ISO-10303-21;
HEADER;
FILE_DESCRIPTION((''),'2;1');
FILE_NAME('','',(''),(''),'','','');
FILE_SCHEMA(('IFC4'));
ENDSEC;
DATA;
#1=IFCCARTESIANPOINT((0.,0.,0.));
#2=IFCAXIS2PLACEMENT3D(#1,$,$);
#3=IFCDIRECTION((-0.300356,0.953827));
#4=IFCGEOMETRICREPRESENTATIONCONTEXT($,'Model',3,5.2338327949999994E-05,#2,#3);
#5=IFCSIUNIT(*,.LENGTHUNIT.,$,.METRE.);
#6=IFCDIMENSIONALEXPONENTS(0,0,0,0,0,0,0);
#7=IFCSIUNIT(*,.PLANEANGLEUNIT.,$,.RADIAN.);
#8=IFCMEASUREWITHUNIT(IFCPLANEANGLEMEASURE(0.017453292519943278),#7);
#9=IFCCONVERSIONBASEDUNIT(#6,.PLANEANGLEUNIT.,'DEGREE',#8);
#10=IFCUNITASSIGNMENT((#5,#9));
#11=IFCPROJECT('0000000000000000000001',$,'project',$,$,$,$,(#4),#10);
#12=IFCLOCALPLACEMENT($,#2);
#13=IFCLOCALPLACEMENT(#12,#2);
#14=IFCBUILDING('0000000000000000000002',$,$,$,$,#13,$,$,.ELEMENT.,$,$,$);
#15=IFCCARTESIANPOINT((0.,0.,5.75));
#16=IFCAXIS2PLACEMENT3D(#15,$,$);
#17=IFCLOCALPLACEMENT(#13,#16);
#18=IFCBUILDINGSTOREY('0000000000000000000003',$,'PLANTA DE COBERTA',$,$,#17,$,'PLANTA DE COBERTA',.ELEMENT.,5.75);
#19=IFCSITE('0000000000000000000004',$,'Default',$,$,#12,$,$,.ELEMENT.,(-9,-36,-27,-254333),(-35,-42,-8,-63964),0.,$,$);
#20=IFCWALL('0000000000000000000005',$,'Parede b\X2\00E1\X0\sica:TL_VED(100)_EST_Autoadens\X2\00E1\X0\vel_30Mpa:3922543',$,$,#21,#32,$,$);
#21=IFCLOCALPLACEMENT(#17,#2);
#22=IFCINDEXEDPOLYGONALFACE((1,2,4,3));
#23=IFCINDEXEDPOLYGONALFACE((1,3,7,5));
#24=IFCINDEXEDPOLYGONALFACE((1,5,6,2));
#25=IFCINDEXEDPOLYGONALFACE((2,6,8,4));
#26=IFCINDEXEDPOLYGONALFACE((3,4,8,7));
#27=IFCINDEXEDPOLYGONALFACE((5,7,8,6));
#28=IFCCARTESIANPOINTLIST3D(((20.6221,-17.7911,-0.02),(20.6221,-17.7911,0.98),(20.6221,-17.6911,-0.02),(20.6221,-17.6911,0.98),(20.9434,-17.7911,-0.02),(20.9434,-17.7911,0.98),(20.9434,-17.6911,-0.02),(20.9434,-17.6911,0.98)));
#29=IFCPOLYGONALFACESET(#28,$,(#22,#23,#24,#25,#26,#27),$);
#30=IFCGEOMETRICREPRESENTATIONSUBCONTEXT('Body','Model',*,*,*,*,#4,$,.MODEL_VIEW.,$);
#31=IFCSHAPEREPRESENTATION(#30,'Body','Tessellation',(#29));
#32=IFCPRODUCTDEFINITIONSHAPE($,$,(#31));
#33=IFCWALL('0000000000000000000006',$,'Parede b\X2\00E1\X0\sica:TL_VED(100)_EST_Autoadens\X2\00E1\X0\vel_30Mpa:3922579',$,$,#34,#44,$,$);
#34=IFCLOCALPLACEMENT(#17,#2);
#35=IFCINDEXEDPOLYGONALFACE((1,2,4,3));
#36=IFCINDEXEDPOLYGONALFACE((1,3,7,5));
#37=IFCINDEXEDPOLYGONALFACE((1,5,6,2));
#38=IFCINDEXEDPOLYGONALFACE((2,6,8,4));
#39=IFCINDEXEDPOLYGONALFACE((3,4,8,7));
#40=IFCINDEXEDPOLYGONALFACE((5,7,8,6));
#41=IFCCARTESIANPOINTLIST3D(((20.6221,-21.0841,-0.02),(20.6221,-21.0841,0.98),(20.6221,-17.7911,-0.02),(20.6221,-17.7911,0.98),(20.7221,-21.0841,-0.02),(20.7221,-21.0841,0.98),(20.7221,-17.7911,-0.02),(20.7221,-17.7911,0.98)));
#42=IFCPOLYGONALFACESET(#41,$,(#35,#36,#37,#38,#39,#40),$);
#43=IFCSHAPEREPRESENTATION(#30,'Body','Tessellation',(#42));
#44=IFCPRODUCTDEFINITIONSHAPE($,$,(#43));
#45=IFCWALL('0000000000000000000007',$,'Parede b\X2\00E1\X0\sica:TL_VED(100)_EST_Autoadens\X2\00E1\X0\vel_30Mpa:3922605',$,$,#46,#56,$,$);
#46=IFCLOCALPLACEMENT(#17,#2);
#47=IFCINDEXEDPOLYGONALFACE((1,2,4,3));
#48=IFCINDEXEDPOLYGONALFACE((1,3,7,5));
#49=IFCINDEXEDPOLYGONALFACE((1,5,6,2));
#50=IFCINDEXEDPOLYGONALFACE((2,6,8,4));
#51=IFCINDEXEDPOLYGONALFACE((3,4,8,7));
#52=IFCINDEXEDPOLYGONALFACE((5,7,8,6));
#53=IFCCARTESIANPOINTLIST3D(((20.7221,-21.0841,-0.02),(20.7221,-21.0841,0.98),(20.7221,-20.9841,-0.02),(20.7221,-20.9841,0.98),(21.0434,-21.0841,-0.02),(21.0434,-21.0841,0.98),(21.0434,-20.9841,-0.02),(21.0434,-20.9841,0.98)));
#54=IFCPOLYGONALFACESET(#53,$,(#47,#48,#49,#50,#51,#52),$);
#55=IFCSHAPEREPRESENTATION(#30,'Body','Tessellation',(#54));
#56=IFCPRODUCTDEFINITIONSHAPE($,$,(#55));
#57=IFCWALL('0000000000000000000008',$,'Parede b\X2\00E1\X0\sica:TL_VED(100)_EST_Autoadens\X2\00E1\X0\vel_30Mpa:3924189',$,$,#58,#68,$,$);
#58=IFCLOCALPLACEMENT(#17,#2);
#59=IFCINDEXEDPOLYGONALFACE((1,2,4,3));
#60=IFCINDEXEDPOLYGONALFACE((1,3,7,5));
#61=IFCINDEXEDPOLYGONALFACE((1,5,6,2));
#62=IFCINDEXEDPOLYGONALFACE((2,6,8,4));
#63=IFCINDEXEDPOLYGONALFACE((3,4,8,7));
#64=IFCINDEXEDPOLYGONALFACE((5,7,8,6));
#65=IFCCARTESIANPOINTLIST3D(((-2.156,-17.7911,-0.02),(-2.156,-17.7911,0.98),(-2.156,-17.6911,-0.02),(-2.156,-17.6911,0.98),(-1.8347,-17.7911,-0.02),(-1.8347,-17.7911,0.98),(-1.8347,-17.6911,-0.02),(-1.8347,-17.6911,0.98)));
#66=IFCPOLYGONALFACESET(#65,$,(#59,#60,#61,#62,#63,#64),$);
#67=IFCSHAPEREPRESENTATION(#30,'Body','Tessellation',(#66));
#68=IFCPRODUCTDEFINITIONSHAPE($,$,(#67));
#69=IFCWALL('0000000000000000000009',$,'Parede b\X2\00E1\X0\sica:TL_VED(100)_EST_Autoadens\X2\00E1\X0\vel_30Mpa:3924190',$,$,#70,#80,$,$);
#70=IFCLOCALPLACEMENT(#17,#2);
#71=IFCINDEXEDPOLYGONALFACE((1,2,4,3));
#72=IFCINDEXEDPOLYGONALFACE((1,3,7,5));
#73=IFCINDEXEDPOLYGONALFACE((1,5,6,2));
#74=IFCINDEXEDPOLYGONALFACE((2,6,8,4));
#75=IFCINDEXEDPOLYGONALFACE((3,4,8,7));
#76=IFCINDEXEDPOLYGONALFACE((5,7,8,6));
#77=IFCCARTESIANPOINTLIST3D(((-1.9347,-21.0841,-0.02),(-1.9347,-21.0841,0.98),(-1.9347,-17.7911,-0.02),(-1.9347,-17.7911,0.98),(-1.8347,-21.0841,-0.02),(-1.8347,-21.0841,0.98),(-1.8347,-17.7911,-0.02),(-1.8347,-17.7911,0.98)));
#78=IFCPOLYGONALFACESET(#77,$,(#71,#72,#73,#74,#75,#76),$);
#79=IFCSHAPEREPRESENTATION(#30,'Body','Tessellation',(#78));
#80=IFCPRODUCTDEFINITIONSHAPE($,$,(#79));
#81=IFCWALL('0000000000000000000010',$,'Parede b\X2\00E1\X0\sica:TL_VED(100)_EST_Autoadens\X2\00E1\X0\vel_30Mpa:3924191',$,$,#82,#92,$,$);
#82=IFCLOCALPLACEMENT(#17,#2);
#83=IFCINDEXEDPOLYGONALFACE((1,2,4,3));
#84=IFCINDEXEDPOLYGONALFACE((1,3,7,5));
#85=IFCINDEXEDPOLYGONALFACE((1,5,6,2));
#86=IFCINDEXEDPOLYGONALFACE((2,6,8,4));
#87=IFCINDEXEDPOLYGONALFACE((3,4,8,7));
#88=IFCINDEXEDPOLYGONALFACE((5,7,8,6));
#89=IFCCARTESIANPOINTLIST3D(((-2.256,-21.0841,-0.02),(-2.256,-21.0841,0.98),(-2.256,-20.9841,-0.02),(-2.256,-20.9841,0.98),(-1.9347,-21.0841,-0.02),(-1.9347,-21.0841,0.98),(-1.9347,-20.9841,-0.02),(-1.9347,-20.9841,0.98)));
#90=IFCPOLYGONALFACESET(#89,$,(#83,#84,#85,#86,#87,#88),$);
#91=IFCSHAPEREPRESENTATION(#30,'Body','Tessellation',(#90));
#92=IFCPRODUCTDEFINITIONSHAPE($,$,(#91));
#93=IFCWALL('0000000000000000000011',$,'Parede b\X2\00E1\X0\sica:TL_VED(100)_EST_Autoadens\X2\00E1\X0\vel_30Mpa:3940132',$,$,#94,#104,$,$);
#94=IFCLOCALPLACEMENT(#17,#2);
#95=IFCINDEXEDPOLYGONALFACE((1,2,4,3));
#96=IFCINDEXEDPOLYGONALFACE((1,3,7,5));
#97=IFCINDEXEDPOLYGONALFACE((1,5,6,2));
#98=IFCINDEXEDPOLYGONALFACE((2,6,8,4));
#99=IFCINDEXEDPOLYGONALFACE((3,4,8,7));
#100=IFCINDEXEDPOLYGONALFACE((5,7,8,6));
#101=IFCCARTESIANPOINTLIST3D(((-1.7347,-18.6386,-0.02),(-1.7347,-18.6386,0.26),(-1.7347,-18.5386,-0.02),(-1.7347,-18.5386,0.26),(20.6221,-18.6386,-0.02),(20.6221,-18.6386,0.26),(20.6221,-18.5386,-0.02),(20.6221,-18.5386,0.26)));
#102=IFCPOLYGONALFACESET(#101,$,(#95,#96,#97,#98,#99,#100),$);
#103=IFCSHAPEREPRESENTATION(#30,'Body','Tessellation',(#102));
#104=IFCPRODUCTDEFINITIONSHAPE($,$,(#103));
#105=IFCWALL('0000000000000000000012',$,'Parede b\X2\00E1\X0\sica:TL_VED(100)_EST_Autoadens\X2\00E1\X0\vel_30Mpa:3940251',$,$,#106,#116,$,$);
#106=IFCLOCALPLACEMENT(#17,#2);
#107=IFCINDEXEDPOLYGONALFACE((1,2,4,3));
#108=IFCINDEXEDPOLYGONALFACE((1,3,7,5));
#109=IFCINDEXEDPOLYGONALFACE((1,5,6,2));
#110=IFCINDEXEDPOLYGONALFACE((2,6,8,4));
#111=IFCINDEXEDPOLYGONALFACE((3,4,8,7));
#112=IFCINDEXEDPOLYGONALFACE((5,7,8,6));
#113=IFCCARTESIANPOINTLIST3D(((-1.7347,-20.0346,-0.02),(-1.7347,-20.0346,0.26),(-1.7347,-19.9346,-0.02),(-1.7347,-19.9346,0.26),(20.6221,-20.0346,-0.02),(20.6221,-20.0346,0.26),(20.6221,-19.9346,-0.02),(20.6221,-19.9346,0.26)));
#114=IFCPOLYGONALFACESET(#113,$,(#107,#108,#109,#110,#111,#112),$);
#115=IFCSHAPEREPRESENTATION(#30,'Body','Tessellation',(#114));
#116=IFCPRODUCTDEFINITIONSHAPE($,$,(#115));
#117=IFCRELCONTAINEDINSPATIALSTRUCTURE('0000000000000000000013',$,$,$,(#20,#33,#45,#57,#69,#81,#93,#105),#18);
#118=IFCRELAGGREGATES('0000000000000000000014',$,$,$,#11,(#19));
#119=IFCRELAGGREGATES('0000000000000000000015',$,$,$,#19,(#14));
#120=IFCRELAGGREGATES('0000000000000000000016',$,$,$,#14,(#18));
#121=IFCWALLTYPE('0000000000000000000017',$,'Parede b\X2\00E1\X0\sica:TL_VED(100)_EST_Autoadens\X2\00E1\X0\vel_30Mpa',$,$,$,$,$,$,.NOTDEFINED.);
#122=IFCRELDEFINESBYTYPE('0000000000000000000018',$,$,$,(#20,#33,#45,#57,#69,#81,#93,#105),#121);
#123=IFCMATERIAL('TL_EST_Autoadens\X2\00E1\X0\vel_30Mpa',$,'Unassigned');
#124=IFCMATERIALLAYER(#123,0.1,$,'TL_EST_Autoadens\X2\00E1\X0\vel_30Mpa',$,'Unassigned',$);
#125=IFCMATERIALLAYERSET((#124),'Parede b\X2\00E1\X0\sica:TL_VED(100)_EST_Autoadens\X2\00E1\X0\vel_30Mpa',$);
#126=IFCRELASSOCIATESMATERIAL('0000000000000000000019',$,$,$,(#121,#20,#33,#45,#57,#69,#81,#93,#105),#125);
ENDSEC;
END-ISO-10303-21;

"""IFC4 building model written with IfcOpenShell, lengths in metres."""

from ifc_helpers import new_model, entity, si_unit, converted_unit, direction, frame, frame_2d, origin, place, context, subcontext, project, spatial, rectangle, extrude, material, layer, layer_set, layer_usage, type_object, element, save


model = new_model("IFC4")

# Units and contexts
model_context = context("Model", 3, precision=5.2338327949999994e-05, world=origin(), true_north=direction((-0.300356, 0.953827)))
body_context = subcontext(model_context, "Body", "Model", "MODEL_VIEW")
ifc_project = project(units=[si_unit("LENGTHUNIT", "METRE"), converted_unit("PLANEANGLEUNIT", "DEGREE", entity("IfcPlaneAngleMeasure", 0.017453292519943278), si_unit("PLANEANGLEUNIT", "RADIAN"), dimensions=[0, 0, 0, 0, 0, 0, 0])], contexts=[model_context])

# Site, building, storey
site_placement = place(None, origin())
site = spatial("IfcSite", under=ifc_project, at=site_placement, Name="Default", CompositionType="ELEMENT", RefLatitude=(-9, -36, -27, -254333), RefLongitude=(-35, -42, -8, -63964), RefElevation=0.0)
building_placement = place(site_placement, origin())
building = spatial("IfcBuilding", under=site, at=building_placement, CompositionType="ELEMENT")
storey_placement = place(building_placement, frame((0.0, 0.0, 5.75)))
storey = spatial("IfcBuildingStorey", under=building, at=storey_placement, Name="PLANTA DE COBERTA", LongName="PLANTA DE COBERTA", CompositionType="ELEMENT", Elevation=5.75)

# Walls
ifc_material_1 = material(Name="TL_EST_Autoadensável_30Mpa", Category="Unassigned")
ifc_layer_1 = layer(ifc_material_1, 0.1, Name="TL_EST_Autoadensável_30Mpa", Category="Unassigned")
ifc_layer_set_1 = layer_set([ifc_layer_1], Name="Parede básica:TL_VED(100)_EST_Autoadensável_30Mpa")
ifc_layer_usage_1 = layer_usage(ifc_layer_set_1, "AXIS2", "POSITIVE", -0.05)
wall_type = type_object("IfcWallType", Name="Parede básica:TL_VED(100)_EST_Autoadensável_30Mpa", PredefinedType="NOTDEFINED", material=ifc_layer_set_1)
wall_1_placement = place(storey_placement, frame((20.9434, -17.7411, -0.02), z_axis=(0.0, 0.0, 1.0), x_axis=(-1.0, 0.0, 0.0)))
element("IfcWall", 1, at=wall_1_placement, inside=storey, type_object=wall_type, material=ifc_layer_usage_1, Name="Parede básica:TL_VED(100)_EST_Autoadensável_30Mpa:3922543", context=body_context, shape_type="SweptSolid", body=[
    extrude(rectangle(XDim=0.3213, YDim=0.1, at=frame_2d((0.1606, 0.0), x_axis=(-1.0, 0.0))), origin(), (0.0, 0.0, 1.0), 1.0),
])
ifc_layer_usage_2 = layer_usage(ifc_layer_set_1, "AXIS2", "POSITIVE", -0.05)
wall_2_placement = place(storey_placement, frame((20.6721, -17.7911, -0.02), z_axis=(0.0, 0.0, 1.0), x_axis=(0.0, -1.0, 0.0)))
element("IfcWall", 2, at=wall_2_placement, inside=storey, type_object=wall_type, material=ifc_layer_usage_2, Name="Parede básica:TL_VED(100)_EST_Autoadensável_30Mpa:3922579", context=body_context, shape_type="SweptSolid", body=[
    extrude(rectangle(XDim=3.293, YDim=0.1, at=frame_2d((1.6465, 0.0), x_axis=(-1.0, 0.0))), origin(), (0.0, 0.0, 1.0), 1.0),
])
ifc_layer_usage_3 = layer_usage(ifc_layer_set_1, "AXIS2", "POSITIVE", -0.05)
wall_3_placement = place(storey_placement, frame((20.7221, -21.0341, -0.02)))
element("IfcWall", 3, at=wall_3_placement, inside=storey, type_object=wall_type, material=ifc_layer_usage_3, Name="Parede básica:TL_VED(100)_EST_Autoadensável_30Mpa:3922605", context=body_context, shape_type="SweptSolid", body=[
    extrude(rectangle(XDim=0.3213, YDim=0.1, at=frame_2d((0.1606, 0.0), x_axis=(-1.0, 0.0))), origin(), (0.0, 0.0, 1.0), 1.0),
])
ifc_layer_usage_4 = layer_usage(ifc_layer_set_1, "AXIS2", "NEGATIVE", 0.05)
wall_4_placement = place(storey_placement, frame((-2.156, -17.7411, -0.02)))
element("IfcWall", 4, at=wall_4_placement, inside=storey, type_object=wall_type, material=ifc_layer_usage_4, Name="Parede básica:TL_VED(100)_EST_Autoadensável_30Mpa:3924189", context=body_context, shape_type="SweptSolid", body=[
    extrude(rectangle(XDim=0.3213, YDim=0.1, at=frame_2d((0.1606, 0.0), x_axis=(-1.0, 0.0))), origin(), (0.0, 0.0, 1.0), 1.0),
])
ifc_layer_usage_5 = layer_usage(ifc_layer_set_1, "AXIS2", "NEGATIVE", 0.05)
wall_5_placement = place(storey_placement, frame((-1.8847, -17.7911, -0.02), z_axis=(0.0, 0.0, 1.0), x_axis=(0.0, -1.0, 0.0)))
element("IfcWall", 5, at=wall_5_placement, inside=storey, type_object=wall_type, material=ifc_layer_usage_5, Name="Parede básica:TL_VED(100)_EST_Autoadensável_30Mpa:3924190", context=body_context, shape_type="SweptSolid", body=[
    extrude(rectangle(XDim=3.293, YDim=0.1, at=frame_2d((1.6465, 0.0), x_axis=(-1.0, 0.0))), origin(), (0.0, 0.0, 1.0), 1.0),
])
ifc_layer_usage_6 = layer_usage(ifc_layer_set_1, "AXIS2", "NEGATIVE", 0.05)
wall_6_placement = place(storey_placement, frame((-1.9347, -21.0341, -0.02), z_axis=(0.0, 0.0, 1.0), x_axis=(-1.0, 0.0, 0.0)))
element("IfcWall", 6, at=wall_6_placement, inside=storey, type_object=wall_type, material=ifc_layer_usage_6, Name="Parede básica:TL_VED(100)_EST_Autoadensável_30Mpa:3924191", context=body_context, shape_type="SweptSolid", body=[
    extrude(rectangle(XDim=0.3213, YDim=0.1, at=frame_2d((0.1606, 0.0), x_axis=(-1.0, 0.0))), origin(), (0.0, 0.0, 1.0), 1.0),
])
ifc_layer_usage_7 = layer_usage(ifc_layer_set_1, "AXIS2", "NEGATIVE", 0.05)
wall_7_placement = place(storey_placement, frame((20.6221, -18.5886, -0.02), z_axis=(0.0, 0.0, 1.0), x_axis=(-1.0, 0.0, 0.0)))
element("IfcWall", 7, at=wall_7_placement, inside=storey, type_object=wall_type, material=ifc_layer_usage_7, Name="Parede básica:TL_VED(100)_EST_Autoadensável_30Mpa:3940132", context=body_context, shape_type="SweptSolid", body=[
    extrude(rectangle(XDim=22.3569, YDim=0.1, at=frame_2d((11.1784, 0.0), x_axis=(-1.0, 0.0))), origin(), (0.0, 0.0, 1.0), 0.28),
])
ifc_layer_usage_8 = layer_usage(ifc_layer_set_1, "AXIS2", "POSITIVE", -0.05)
wall_8_placement = place(storey_placement, frame((20.6221, -19.9846, -0.02), z_axis=(0.0, 0.0, 1.0), x_axis=(-1.0, 0.0, 0.0)))
element("IfcWall", 8, at=wall_8_placement, inside=storey, type_object=wall_type, material=ifc_layer_usage_8, Name="Parede básica:TL_VED(100)_EST_Autoadensável_30Mpa:3940251", context=body_context, shape_type="SweptSolid", body=[
    extrude(rectangle(XDim=22.3569, YDim=0.1, at=frame_2d((11.1784, 0.0), x_axis=(-1.0, 0.0))), origin(), (0.0, 0.0, 1.0), 0.28),
])

save(model, "model.ifc")
